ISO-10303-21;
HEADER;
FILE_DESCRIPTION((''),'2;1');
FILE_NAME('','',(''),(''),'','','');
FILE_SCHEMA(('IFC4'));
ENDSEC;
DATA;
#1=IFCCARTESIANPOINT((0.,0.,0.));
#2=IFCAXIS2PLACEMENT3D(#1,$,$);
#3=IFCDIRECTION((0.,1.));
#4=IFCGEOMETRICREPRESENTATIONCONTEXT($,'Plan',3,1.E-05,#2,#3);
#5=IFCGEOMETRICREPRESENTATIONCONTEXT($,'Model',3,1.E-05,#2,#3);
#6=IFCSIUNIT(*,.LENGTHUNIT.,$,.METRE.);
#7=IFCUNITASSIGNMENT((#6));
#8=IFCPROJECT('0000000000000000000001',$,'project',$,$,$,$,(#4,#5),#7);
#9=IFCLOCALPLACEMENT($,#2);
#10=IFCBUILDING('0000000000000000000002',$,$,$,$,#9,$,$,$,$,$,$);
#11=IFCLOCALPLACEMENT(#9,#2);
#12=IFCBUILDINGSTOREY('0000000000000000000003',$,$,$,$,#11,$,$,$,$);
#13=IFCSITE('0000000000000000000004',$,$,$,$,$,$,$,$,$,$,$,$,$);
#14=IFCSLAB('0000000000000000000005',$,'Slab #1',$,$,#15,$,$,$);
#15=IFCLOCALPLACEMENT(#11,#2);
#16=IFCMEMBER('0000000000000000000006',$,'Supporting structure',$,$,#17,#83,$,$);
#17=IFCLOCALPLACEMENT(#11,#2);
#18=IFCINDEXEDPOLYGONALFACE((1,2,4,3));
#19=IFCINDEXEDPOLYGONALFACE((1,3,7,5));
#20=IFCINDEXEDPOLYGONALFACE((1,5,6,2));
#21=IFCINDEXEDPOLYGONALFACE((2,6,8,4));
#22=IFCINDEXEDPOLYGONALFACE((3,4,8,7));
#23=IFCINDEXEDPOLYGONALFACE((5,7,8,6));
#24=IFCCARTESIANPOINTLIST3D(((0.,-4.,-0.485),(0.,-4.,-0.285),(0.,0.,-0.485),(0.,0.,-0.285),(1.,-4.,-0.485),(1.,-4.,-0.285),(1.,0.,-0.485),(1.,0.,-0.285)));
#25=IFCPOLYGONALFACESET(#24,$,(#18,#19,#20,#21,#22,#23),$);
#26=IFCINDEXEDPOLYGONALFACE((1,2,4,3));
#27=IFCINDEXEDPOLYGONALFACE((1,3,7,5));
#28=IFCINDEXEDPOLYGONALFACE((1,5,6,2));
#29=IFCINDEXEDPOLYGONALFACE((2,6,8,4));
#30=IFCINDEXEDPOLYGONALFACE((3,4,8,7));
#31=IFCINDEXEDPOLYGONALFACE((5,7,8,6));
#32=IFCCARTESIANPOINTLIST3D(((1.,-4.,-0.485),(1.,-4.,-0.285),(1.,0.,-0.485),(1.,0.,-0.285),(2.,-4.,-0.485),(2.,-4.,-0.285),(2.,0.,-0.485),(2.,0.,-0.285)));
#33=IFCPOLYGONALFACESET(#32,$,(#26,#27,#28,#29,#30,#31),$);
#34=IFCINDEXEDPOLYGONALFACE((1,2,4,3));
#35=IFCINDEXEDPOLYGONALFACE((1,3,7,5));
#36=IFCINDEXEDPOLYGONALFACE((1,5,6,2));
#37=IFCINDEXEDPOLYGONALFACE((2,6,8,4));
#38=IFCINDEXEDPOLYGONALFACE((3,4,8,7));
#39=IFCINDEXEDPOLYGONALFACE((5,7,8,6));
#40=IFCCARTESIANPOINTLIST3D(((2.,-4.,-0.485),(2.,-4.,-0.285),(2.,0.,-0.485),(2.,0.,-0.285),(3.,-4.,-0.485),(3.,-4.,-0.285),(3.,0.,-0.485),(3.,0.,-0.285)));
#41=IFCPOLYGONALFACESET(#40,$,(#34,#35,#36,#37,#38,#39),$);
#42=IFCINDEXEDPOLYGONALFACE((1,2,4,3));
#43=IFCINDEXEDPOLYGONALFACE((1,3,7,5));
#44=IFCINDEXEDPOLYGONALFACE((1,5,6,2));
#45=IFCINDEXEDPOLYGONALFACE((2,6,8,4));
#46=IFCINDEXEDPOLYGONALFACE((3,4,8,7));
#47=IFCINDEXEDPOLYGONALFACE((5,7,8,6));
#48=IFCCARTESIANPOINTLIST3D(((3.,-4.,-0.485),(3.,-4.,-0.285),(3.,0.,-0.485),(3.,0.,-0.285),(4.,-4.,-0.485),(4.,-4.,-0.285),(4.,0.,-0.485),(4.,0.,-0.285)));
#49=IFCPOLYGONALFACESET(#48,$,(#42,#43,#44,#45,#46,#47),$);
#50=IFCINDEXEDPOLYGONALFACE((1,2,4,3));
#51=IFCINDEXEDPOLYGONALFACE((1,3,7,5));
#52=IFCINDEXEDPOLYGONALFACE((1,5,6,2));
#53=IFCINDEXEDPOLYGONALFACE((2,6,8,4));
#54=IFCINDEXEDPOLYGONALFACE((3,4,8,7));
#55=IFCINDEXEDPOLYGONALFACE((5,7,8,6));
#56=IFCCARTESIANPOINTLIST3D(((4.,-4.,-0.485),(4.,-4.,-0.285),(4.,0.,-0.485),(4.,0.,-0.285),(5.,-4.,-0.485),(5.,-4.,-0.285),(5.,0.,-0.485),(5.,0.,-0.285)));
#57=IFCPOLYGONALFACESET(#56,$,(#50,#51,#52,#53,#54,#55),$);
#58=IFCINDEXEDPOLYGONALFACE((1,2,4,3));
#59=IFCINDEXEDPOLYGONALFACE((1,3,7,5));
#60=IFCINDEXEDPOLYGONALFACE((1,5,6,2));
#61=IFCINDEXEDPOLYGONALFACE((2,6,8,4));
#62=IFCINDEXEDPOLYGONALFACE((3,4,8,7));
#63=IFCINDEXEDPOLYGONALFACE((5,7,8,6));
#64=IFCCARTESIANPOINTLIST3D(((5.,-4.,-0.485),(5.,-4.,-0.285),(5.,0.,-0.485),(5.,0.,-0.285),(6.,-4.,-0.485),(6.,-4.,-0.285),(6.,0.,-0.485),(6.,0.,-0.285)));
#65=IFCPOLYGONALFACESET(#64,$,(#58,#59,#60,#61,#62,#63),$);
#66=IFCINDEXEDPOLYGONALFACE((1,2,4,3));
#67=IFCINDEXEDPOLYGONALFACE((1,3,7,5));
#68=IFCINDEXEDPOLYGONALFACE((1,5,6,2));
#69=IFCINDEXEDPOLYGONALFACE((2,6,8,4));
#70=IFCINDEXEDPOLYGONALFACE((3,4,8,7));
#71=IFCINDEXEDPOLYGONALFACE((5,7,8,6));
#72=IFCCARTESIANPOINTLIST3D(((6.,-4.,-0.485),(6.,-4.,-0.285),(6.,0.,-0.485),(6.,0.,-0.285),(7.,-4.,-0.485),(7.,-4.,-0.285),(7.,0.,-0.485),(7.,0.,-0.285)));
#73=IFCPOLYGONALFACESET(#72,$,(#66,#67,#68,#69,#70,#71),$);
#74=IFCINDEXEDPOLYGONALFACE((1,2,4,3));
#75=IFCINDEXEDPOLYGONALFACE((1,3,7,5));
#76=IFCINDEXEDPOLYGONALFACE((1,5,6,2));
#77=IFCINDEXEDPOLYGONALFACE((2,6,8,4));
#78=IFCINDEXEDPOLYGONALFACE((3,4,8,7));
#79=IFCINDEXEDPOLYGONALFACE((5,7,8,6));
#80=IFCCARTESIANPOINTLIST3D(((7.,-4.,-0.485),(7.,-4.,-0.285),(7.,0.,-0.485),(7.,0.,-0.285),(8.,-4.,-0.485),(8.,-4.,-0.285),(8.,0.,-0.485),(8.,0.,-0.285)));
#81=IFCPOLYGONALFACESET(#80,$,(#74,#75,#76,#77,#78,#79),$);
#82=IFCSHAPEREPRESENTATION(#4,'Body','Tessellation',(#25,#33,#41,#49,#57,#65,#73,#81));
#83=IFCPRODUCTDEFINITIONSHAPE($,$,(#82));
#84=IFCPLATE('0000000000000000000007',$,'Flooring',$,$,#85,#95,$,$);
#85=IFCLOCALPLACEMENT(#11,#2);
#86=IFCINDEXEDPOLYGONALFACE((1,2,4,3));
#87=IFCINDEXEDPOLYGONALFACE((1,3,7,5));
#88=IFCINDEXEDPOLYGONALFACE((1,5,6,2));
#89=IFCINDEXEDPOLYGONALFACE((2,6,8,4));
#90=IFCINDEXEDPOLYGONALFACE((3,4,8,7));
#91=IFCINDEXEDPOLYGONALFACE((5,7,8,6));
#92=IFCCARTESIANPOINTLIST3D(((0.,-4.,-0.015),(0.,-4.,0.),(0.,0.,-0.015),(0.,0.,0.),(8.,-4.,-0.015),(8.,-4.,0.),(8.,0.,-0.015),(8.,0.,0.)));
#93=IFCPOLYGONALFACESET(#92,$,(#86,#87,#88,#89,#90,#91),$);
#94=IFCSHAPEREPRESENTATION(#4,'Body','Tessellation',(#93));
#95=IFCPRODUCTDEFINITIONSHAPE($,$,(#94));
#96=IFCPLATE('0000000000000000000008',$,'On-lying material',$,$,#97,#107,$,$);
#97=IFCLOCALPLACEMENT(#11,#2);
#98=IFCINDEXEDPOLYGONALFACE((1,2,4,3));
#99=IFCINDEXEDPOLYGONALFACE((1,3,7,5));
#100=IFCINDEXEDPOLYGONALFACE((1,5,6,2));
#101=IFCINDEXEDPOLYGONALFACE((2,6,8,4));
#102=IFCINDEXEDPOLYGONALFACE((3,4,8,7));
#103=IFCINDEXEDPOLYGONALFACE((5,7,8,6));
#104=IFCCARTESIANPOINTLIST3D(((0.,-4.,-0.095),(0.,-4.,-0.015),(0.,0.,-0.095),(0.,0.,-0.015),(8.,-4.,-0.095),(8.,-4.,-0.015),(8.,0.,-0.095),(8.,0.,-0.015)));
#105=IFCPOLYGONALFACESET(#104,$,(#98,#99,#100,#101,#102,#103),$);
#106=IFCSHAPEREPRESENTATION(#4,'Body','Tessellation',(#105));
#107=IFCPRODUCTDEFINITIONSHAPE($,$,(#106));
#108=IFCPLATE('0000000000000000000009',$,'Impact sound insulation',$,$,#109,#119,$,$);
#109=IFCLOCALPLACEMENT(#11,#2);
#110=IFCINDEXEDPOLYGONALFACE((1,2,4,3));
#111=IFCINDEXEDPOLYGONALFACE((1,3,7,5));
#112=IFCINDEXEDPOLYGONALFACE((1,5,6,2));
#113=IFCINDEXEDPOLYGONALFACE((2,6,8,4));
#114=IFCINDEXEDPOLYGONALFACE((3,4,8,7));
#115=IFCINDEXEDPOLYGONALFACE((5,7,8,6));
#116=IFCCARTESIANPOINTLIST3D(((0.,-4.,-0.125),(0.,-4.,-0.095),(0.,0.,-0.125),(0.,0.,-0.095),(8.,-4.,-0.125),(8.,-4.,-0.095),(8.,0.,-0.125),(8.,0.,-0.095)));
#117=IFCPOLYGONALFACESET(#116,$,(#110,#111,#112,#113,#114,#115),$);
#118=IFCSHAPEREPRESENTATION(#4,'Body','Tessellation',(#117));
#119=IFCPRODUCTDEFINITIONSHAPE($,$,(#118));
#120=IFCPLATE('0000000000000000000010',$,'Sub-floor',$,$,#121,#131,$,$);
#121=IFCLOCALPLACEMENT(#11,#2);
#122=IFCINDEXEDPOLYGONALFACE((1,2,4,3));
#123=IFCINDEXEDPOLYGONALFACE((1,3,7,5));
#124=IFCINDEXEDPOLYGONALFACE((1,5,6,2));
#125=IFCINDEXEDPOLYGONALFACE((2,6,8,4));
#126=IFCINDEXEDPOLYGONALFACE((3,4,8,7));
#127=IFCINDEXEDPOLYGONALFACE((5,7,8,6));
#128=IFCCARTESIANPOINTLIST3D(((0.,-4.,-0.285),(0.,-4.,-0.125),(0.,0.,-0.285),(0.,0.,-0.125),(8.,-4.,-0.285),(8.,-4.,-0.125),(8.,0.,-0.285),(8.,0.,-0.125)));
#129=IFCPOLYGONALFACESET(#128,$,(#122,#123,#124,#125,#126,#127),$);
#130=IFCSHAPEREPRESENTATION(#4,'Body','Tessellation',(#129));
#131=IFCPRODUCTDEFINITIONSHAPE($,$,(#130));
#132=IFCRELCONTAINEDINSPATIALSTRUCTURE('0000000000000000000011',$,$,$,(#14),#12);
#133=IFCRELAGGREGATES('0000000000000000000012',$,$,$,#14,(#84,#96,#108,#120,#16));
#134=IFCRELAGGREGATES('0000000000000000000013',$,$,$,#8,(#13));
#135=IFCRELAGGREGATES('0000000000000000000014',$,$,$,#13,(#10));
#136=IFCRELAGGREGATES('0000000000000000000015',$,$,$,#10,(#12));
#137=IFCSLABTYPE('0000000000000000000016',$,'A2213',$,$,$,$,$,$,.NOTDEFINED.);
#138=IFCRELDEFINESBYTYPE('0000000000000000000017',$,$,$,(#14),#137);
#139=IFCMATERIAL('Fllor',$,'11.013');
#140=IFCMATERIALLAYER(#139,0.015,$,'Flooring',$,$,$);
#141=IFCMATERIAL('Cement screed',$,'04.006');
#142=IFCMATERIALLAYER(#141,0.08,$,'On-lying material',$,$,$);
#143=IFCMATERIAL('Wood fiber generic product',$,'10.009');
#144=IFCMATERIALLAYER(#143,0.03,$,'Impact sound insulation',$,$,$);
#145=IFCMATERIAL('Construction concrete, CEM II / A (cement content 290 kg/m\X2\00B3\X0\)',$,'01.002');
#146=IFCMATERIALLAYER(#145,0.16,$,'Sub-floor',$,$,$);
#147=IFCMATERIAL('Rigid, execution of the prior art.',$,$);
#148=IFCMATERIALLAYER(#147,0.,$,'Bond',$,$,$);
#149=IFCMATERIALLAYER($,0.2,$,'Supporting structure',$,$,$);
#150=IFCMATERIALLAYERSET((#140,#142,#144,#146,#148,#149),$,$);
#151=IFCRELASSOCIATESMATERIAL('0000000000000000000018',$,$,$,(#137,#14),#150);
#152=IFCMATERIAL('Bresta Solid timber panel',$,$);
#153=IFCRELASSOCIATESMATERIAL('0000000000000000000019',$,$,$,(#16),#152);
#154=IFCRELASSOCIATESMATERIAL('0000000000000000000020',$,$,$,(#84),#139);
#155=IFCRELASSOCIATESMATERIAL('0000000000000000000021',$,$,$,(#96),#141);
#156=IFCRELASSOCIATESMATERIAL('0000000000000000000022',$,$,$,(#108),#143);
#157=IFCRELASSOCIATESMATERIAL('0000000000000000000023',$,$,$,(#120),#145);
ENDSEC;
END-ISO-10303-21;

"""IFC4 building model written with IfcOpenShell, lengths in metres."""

from ifc_helpers import new_model, si_unit, direction, frame, frame_2d, origin, origin_with_axes, place, context, project, spatial, rectangle, extrude, material, layer, layer_set, type_object, element, aggregate, save


model = new_model("IFC4")

# Units and contexts
plan_context = context("Plan", 3, precision=1e-05, world=origin(), true_north=direction((0.0, 1.0)))
model_context = context("Model", 3, precision=1e-05, world=origin(), true_north=direction((0.0, 1.0)))
ifc_project = project(units=[si_unit("LENGTHUNIT", "METRE")], contexts=[plan_context, model_context])

# Site, building, storey
site = spatial("IfcSite", under=ifc_project)
building_placement = place(None, origin())
building = spatial("IfcBuilding", under=site, at=building_placement)
storey_placement = place(building_placement, origin())
storey = spatial("IfcBuildingStorey", under=building, at=storey_placement)

# Slab, member, plates
ifc_material_1 = material(Name="Fllor", Category="11.013")
ifc_layer_1 = layer(ifc_material_1, 0.015, Name="Flooring")
ifc_material_2 = material(Name="Cement screed", Category="04.006")
ifc_layer_2 = layer(ifc_material_2, 0.08, Name="On-lying material")
ifc_material_3 = material(Name="Wood fiber generic product", Category="10.009")
ifc_layer_3 = layer(ifc_material_3, 0.03, Name="Impact sound insulation")
ifc_material_4 = material(Name="Construction concrete, CEM II / A (cement content 290 kg/m³)", Category="01.002")
ifc_layer_4 = layer(ifc_material_4, 0.16, Name="Sub-floor")
ifc_material_5 = material(Name="Rigid, execution of the prior art.")
ifc_layer_5 = layer(ifc_material_5, 0.0, Name="Bond")
ifc_layer_6 = layer(None, 0.2, Name="Supporting structure")
ifc_layer_set = layer_set([ifc_layer_1, ifc_layer_2, ifc_layer_3, ifc_layer_4, ifc_layer_5, ifc_layer_6])
slab_type = type_object("IfcSlabType", Name="A2213", PredefinedType="NOTDEFINED", material=ifc_layer_set)
slab_placement = place(None, frame((0.0, 0.0, 0.0), z_axis=(0.0, 0.0, -1.0), x_axis=(1.0, 0.0, 0.0)))
slab = element("IfcSlab", 1, at=slab_placement, inside=storey, type_object=slab_type, material=ifc_layer_set, Name="Slab #1")
ifc_material_6 = material(Name="Bresta Solid timber panel")
member_placement = place(slab_placement, origin())
member = element("IfcMember", 2, at=member_placement, material=ifc_material_6, Name="Supporting structure", context=plan_context, shape_type="SweptSolid", body=[
    extrude(rectangle(XDim=1.0, YDim=0.2, at=frame_2d((0.5, 0.1), x_axis=(1.0, 0.0))), frame((0.0, 4.0, 0.285), z_axis=(0.0, -1.0, 0.0), x_axis=(1.0, 0.0, 0.0)), (0.0, 0.0, 1.0), 4.0),
    extrude(rectangle(XDim=1.0, YDim=0.2, at=frame_2d((0.5, 0.1), x_axis=(1.0, 0.0))), frame((1.0, 4.0, 0.285), z_axis=(0.0, -1.0, 0.0), x_axis=(1.0, 0.0, 0.0)), (0.0, 0.0, 1.0), 4.0),
    extrude(rectangle(XDim=1.0, YDim=0.2, at=frame_2d((0.5, 0.1), x_axis=(1.0, 0.0))), frame((2.0, 4.0, 0.285), z_axis=(0.0, -1.0, 0.0), x_axis=(1.0, 0.0, 0.0)), (0.0, 0.0, 1.0), 4.0),
    extrude(rectangle(XDim=1.0, YDim=0.2, at=frame_2d((0.5, 0.1), x_axis=(1.0, 0.0))), frame((3.0, 4.0, 0.285), z_axis=(0.0, -1.0, 0.0), x_axis=(1.0, 0.0, 0.0)), (0.0, 0.0, 1.0), 4.0),
    extrude(rectangle(XDim=1.0, YDim=0.2, at=frame_2d((0.5, 0.1), x_axis=(1.0, 0.0))), frame((4.0, 4.0, 0.285), z_axis=(0.0, -1.0, 0.0), x_axis=(1.0, 0.0, 0.0)), (0.0, 0.0, 1.0), 4.0),
    extrude(rectangle(XDim=1.0, YDim=0.2, at=frame_2d((0.5, 0.1), x_axis=(1.0, 0.0))), frame((5.0, 4.0, 0.285), z_axis=(0.0, -1.0, 0.0), x_axis=(1.0, 0.0, 0.0)), (0.0, 0.0, 1.0), 4.0),
    extrude(rectangle(XDim=1.0, YDim=0.2, at=frame_2d((0.5, 0.1), x_axis=(1.0, 0.0))), frame((6.0, 4.0, 0.285), z_axis=(0.0, -1.0, 0.0), x_axis=(1.0, 0.0, 0.0)), (0.0, 0.0, 1.0), 4.0),
    extrude(rectangle(XDim=1.0, YDim=0.2, at=frame_2d((0.5, 0.1), x_axis=(1.0, 0.0))), frame((7.0, 4.0, 0.285), z_axis=(0.0, -1.0, 0.0), x_axis=(1.0, 0.0, 0.0)), (0.0, 0.0, 1.0), 4.0),
])
plate_1_placement = place(slab_placement, origin())
plate_1 = element("IfcPlate", 3, at=plate_1_placement, material=ifc_material_1, Name="Flooring", context=plan_context, shape_type="SweptSolid", body=[
    extrude(rectangle(XDim=8.0, YDim=4.0, at=frame_2d((4.0, 2.0), x_axis=(1.0, 0.0))), origin_with_axes(), (0.0, 0.0, 1.0), 0.015),
])
plate_2_placement = place(slab_placement, origin())
plate_2 = element("IfcPlate", 4, at=plate_2_placement, material=ifc_material_2, Name="On-lying material", context=plan_context, shape_type="SweptSolid", body=[
    extrude(rectangle(XDim=8.0, YDim=4.0, at=frame_2d((4.0, 2.0), x_axis=(1.0, 0.0))), frame((0.0, 0.0, 0.015), z_axis=(0.0, 0.0, 1.0), x_axis=(1.0, 0.0, 0.0)), (0.0, 0.0, 1.0), 0.08),
])
plate_3_placement = place(slab_placement, origin())
plate_3 = element("IfcPlate", 5, at=plate_3_placement, material=ifc_material_3, Name="Impact sound insulation", context=plan_context, shape_type="SweptSolid", body=[
    extrude(rectangle(XDim=8.0, YDim=4.0, at=frame_2d((4.0, 2.0), x_axis=(1.0, 0.0))), frame((0.0, 0.0, 0.095), z_axis=(0.0, 0.0, 1.0), x_axis=(1.0, 0.0, 0.0)), (0.0, 0.0, 1.0), 0.03),
])
plate_4_placement = place(slab_placement, origin())
plate_4 = element("IfcPlate", 6, at=plate_4_placement, material=ifc_material_4, Name="Sub-floor", context=plan_context, shape_type="SweptSolid", body=[
    extrude(rectangle(XDim=8.0, YDim=4.0, at=frame_2d((4.0, 2.0), x_axis=(1.0, 0.0))), frame((0.0, 0.0, 0.125), z_axis=(0.0, 0.0, 1.0), x_axis=(1.0, 0.0, 0.0)), (0.0, 0.0, 1.0), 0.16),
])
aggregate(slab, [plate_1, plate_2, plate_3, plate_4, member])

save(model, "model.ifc")
